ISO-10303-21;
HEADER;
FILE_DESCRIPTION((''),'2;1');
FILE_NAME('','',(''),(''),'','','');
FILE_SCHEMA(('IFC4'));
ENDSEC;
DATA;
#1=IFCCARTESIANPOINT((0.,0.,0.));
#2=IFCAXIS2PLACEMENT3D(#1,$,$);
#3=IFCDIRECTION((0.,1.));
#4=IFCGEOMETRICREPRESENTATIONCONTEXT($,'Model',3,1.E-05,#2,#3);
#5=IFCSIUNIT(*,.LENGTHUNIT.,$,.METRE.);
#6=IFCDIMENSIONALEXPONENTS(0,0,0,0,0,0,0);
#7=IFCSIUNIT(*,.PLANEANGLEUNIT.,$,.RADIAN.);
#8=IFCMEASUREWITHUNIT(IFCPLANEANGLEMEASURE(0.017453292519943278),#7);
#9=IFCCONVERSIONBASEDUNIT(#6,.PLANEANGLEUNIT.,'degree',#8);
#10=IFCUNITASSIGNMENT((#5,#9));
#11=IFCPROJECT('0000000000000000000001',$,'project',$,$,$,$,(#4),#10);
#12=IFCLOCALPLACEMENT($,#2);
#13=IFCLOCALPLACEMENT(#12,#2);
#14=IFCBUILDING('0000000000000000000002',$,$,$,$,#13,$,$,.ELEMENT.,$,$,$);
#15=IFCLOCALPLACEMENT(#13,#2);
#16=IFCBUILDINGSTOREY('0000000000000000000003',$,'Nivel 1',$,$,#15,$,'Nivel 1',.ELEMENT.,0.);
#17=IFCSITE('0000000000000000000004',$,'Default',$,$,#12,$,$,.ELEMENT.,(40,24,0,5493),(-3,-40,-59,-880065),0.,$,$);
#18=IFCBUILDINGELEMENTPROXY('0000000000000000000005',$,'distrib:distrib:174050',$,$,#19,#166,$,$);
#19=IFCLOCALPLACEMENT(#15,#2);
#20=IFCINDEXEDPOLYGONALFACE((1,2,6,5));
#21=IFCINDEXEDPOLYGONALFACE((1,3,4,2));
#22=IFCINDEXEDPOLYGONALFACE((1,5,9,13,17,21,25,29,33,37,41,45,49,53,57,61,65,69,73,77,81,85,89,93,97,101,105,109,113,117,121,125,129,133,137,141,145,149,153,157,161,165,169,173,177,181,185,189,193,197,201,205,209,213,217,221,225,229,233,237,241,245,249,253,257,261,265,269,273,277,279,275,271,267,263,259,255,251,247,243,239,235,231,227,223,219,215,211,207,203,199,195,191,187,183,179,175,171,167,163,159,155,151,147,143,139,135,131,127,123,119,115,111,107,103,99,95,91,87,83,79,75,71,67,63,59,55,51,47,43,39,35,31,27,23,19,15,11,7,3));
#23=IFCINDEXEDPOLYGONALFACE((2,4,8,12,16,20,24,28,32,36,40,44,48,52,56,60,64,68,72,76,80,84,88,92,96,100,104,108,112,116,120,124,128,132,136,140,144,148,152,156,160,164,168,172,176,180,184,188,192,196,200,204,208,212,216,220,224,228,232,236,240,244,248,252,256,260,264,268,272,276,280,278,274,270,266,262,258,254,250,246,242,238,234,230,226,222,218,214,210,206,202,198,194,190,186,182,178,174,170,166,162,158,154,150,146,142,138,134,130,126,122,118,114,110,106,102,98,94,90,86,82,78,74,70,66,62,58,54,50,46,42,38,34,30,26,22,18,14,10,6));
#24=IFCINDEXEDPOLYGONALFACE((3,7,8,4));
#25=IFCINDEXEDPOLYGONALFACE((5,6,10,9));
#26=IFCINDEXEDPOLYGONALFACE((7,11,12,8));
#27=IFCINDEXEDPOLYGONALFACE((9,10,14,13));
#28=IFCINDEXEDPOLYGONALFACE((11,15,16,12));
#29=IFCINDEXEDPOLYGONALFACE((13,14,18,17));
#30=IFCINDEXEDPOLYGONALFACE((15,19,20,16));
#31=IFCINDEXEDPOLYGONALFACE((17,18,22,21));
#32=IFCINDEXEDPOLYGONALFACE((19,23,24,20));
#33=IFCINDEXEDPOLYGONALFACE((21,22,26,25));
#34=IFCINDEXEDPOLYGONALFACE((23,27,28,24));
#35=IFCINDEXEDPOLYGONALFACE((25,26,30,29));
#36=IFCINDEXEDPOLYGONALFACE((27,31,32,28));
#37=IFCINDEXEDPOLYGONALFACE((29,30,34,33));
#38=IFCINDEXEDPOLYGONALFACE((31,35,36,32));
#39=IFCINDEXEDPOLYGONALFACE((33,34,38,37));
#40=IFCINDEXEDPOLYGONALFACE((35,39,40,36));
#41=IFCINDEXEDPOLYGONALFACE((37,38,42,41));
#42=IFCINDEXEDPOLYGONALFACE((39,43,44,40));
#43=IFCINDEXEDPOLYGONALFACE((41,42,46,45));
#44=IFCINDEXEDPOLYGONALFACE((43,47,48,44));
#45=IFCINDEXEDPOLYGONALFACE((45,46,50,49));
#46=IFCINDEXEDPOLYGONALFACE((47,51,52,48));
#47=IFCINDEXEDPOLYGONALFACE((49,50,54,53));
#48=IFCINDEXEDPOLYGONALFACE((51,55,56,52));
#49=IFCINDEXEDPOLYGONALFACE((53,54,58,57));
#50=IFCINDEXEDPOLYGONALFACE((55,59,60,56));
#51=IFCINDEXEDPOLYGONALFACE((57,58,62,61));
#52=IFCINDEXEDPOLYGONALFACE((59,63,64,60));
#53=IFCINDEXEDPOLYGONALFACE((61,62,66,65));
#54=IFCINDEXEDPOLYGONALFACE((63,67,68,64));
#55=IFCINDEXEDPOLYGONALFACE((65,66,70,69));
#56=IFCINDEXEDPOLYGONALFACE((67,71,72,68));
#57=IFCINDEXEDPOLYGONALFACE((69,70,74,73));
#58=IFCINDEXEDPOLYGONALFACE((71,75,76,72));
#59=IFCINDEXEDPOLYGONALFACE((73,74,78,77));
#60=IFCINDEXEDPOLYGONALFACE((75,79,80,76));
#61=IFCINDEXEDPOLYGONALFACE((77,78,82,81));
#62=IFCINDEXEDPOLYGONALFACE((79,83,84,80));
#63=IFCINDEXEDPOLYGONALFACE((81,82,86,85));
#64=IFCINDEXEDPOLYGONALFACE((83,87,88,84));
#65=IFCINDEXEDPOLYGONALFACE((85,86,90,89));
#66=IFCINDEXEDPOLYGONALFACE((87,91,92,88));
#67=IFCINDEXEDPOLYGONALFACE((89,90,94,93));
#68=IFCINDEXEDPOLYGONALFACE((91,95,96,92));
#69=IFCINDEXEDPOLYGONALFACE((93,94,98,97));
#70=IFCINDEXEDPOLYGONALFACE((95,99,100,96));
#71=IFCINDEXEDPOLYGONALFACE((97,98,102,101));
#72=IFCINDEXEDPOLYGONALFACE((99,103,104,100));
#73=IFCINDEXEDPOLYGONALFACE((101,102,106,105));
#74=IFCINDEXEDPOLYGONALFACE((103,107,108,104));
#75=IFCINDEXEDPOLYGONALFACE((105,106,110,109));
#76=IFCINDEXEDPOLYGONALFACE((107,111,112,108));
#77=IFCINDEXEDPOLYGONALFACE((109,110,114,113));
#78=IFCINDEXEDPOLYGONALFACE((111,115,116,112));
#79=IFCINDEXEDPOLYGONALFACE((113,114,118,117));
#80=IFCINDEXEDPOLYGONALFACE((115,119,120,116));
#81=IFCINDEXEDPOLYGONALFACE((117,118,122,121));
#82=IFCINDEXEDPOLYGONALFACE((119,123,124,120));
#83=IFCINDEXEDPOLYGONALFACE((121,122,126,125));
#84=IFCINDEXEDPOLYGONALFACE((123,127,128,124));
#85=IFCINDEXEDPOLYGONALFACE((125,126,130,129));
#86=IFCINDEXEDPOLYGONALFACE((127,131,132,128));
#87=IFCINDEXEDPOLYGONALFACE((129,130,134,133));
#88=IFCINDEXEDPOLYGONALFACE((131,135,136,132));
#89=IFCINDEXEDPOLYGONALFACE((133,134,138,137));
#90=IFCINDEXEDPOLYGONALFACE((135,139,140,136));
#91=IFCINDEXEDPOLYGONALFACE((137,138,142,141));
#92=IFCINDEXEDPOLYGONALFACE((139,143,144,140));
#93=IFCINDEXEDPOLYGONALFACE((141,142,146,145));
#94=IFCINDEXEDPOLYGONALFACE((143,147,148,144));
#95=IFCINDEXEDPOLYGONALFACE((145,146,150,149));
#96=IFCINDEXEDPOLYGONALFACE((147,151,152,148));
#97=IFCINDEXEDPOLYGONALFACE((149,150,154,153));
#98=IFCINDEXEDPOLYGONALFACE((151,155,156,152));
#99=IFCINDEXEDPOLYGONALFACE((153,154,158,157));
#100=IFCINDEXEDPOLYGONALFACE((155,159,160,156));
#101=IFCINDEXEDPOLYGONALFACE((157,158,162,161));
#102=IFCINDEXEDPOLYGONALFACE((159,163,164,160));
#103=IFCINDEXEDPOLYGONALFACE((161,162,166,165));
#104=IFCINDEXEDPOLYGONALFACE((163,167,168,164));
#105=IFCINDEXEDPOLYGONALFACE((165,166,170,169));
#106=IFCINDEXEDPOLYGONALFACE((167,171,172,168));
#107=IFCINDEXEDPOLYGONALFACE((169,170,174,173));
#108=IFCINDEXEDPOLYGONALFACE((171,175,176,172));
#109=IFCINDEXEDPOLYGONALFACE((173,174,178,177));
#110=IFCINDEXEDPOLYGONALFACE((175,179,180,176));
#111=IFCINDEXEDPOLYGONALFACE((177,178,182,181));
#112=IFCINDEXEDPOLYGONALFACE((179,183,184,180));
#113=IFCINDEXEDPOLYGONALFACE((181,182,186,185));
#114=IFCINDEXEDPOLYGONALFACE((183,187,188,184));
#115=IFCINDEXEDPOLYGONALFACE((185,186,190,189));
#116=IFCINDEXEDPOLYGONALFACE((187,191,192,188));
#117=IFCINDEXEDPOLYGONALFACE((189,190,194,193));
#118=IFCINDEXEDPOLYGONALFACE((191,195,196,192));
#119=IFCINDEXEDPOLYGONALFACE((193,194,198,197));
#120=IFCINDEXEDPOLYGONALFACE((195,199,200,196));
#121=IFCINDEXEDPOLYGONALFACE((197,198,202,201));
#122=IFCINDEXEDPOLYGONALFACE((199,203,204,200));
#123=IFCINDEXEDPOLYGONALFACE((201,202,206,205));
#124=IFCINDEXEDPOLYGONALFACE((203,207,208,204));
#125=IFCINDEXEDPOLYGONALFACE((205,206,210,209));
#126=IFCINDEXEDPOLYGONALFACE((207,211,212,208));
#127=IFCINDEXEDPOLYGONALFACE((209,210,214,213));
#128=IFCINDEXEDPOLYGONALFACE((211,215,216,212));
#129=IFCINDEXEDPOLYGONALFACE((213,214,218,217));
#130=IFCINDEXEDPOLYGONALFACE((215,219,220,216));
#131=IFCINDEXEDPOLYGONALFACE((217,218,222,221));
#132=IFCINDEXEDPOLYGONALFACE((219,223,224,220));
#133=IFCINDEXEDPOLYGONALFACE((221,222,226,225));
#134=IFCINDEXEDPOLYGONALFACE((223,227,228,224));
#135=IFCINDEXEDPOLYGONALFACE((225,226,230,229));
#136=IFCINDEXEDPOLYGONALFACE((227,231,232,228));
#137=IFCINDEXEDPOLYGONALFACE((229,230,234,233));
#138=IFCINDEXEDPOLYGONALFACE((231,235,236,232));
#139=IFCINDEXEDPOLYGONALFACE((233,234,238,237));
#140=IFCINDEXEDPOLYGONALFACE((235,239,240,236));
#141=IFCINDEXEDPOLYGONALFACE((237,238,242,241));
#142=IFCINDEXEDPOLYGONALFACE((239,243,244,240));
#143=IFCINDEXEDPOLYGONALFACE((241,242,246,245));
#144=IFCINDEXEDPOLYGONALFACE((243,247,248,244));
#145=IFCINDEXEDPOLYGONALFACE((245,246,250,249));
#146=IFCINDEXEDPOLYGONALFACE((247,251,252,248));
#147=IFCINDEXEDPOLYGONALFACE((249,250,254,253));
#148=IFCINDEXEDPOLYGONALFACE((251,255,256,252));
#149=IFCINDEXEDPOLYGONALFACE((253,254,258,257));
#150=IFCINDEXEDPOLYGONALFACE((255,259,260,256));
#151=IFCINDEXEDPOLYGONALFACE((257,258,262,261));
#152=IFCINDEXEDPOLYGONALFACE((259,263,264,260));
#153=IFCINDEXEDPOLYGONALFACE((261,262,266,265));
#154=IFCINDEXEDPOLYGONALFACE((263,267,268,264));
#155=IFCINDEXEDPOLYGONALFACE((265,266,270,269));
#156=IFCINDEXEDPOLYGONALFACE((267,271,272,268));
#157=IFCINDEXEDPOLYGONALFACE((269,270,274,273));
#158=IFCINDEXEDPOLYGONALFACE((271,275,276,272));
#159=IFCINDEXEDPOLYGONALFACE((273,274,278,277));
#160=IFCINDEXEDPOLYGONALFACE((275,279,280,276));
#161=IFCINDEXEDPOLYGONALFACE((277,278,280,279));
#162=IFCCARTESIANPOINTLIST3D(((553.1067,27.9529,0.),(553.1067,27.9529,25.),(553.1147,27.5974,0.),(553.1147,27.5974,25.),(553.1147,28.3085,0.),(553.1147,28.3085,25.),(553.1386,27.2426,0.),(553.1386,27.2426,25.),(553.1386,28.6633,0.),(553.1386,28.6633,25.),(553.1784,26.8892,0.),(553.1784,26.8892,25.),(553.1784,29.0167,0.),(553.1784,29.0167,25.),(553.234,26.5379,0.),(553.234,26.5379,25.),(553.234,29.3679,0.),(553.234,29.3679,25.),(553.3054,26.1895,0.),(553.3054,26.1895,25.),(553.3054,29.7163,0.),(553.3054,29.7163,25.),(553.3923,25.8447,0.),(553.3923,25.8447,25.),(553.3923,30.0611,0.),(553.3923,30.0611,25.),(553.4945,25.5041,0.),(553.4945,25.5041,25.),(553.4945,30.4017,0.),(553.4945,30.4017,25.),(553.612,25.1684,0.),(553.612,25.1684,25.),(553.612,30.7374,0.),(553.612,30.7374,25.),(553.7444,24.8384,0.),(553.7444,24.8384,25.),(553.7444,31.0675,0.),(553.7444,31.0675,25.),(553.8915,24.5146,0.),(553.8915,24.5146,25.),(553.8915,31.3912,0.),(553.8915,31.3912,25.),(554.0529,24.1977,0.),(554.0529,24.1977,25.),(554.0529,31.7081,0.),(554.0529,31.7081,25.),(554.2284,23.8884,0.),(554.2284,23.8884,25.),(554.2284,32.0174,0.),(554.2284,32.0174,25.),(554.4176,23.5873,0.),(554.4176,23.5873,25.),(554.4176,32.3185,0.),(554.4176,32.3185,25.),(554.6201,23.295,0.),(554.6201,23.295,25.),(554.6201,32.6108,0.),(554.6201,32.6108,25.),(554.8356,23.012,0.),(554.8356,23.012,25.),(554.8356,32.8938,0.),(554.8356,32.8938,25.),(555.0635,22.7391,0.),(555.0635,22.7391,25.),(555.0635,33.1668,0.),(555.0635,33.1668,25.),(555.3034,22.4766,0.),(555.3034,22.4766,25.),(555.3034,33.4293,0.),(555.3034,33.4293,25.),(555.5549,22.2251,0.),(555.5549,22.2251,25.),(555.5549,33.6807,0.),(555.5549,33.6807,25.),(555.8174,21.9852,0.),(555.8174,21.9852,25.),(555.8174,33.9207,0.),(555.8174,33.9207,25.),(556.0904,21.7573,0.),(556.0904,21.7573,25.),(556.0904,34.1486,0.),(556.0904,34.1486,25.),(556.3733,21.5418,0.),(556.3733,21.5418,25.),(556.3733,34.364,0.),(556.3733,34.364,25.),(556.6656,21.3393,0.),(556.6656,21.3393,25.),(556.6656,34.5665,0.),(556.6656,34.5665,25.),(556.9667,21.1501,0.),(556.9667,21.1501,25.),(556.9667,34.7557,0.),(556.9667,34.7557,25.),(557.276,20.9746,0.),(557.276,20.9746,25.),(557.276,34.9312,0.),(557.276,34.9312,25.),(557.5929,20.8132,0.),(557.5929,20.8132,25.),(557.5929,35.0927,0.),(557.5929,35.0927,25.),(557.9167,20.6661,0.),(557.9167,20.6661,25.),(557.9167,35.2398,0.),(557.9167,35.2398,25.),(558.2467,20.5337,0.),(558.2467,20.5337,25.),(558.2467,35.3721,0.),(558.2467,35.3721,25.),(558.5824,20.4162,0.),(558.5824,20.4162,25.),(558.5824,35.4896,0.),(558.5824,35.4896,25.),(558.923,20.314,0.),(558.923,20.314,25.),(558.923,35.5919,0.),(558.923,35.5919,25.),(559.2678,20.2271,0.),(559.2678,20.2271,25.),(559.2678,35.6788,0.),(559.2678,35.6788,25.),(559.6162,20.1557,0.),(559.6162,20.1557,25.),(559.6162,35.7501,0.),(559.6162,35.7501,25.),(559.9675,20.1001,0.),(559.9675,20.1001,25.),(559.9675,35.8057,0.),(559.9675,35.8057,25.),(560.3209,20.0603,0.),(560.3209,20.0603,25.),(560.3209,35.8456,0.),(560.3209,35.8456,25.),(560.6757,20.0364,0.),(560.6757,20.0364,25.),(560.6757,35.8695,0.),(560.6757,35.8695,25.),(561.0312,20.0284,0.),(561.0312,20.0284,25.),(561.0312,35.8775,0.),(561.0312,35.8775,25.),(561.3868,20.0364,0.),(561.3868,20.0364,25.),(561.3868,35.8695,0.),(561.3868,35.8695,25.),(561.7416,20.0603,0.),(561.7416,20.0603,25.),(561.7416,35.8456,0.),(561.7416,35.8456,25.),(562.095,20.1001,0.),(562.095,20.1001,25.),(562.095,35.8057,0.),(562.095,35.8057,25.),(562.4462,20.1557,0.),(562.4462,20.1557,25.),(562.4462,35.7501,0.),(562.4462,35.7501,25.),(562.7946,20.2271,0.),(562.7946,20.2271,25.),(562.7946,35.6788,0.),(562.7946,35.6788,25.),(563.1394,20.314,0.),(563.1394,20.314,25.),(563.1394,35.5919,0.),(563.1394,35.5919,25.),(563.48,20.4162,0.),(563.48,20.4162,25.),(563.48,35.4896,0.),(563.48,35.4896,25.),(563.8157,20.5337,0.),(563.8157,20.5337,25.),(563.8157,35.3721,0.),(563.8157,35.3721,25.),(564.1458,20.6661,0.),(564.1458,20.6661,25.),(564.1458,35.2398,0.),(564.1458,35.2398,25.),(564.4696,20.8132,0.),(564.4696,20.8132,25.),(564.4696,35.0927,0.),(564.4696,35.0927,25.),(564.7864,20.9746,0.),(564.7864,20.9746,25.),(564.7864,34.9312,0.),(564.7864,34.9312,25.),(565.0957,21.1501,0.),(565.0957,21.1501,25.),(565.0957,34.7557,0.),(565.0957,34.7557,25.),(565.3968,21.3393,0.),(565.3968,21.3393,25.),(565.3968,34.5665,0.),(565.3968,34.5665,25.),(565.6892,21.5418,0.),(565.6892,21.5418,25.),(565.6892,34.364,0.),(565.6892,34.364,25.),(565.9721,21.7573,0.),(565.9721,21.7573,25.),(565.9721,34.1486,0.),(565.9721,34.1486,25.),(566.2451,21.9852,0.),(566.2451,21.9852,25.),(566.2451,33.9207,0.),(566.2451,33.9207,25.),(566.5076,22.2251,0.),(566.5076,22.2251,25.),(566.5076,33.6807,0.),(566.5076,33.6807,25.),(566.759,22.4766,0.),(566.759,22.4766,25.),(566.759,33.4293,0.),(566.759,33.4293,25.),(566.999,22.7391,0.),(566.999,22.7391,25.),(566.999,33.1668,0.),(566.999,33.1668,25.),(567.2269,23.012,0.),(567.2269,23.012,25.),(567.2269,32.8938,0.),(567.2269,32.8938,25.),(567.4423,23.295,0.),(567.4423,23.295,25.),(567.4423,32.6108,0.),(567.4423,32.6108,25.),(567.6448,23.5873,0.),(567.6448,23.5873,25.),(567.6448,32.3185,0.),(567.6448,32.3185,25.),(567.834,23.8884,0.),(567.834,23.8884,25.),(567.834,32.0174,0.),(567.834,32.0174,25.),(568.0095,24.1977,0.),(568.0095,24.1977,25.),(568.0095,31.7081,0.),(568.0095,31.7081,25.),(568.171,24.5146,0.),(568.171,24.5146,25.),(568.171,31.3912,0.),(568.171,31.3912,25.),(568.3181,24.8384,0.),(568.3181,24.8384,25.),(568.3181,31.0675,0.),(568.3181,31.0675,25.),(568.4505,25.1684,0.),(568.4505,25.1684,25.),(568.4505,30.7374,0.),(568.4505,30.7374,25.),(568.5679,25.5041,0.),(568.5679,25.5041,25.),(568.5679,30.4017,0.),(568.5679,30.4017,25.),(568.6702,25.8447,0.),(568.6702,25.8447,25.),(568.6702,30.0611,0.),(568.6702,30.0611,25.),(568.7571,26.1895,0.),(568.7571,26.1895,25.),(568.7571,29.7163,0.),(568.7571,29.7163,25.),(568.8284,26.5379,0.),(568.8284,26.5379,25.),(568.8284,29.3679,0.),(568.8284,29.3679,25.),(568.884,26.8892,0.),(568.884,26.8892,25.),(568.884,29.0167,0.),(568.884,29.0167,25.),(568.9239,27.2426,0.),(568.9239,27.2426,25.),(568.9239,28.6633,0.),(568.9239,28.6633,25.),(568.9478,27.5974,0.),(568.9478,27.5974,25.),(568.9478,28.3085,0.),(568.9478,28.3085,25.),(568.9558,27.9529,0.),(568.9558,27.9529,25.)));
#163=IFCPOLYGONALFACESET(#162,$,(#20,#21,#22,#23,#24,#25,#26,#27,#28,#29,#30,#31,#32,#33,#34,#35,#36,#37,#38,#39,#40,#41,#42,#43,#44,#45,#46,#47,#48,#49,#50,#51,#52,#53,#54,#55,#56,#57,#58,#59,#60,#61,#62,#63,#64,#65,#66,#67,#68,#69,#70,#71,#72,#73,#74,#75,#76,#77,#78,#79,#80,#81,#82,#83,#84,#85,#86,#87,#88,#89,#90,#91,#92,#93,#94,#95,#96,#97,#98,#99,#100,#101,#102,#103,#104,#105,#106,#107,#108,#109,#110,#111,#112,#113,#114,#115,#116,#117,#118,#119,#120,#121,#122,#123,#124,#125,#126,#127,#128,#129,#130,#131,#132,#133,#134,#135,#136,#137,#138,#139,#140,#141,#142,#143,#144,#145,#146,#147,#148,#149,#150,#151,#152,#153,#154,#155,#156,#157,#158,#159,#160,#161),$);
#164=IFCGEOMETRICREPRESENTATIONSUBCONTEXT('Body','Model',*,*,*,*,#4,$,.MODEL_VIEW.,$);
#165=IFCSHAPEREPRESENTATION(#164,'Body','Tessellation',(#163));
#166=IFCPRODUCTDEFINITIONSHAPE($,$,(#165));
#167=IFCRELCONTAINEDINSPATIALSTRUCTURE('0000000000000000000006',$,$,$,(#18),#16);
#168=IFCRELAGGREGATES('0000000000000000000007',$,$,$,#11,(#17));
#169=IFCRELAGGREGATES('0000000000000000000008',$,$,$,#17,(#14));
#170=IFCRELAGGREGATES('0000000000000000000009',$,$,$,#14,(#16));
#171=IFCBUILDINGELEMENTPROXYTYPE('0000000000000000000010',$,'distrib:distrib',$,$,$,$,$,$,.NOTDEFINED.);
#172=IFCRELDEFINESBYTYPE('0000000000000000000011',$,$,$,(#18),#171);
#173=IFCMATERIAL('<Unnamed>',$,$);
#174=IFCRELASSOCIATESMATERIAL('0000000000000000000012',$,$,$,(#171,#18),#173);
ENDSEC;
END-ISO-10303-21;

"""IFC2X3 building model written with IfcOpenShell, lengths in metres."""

from ifc_helpers import new_model, entity, si_unit, converted_unit, direction, frame, frame_2d, origin, place, context, subcontext, project, spatial, circle, extrude, source, transform, mapped, material, type_object, type_shapes, element, save


model = new_model("IFC2X3")

# Units and contexts
model_context = context("Model", 3, precision=1e-05, world=origin(), true_north=direction((0.0, 1.0)))
body_context = subcontext(model_context, "Body", "Model", "MODEL_VIEW")
ifc_project = project(units=[si_unit("LENGTHUNIT", "METRE"), converted_unit("PLANEANGLEUNIT", "degree", entity("IfcPlaneAngleMeasure", 0.017453292519943278), si_unit("PLANEANGLEUNIT", "RADIAN"), dimensions=[0, 0, 0, 0, 0, 0, 0])], contexts=[model_context])

# Site, building, storey
site_placement = place(None, origin())
site = spatial("IfcSite", under=ifc_project, at=site_placement, Name="Default", CompositionType="ELEMENT", RefLatitude=(40, 24, 0, 5493), RefLongitude=(-3, -40, -59, -880065), RefElevation=0.0)
building_placement = place(site_placement, origin())
building = spatial("IfcBuilding", under=site, at=building_placement, CompositionType="ELEMENT")
storey_placement = place(building_placement, origin())
storey = spatial("IfcBuildingStorey", under=building, at=storey_placement, Name="Nivel 1", LongName="Nivel 1", CompositionType="ELEMENT", Elevation=0.0)

# Building element proxy
ifc_material_1 = material(Name="<Unnamed>")
building_element_proxy_type_1 = type_object("IfcBuildingElementProxyType", Name="distrib:distrib", PredefinedType="NOTDEFINED", material=ifc_material_1)
shared_shape_1 = source(origin(), body_context, "Body", "SweptSolid", [
    extrude(circle(Radius=7.9245, at=frame_2d((0.0, 0.0), x_axis=(1.0, 0.0))), frame((561.0312, 27.9529, 0.0)), (0.0, 0.0, 1.0), 25.0),
])
type_shapes(building_element_proxy_type_1, [shared_shape_1])
proxy_1_placement = place(storey_placement, origin())
element("IfcBuildingElementProxy", 1, at=proxy_1_placement, inside=storey, type_object=building_element_proxy_type_1, material=ifc_material_1, Name="distrib:distrib:174050", context=body_context, shape_type="MappedRepresentation", body=[
    mapped(shared_shape_1, transform((0.0, 0.0, 0.0), scale=1.0)),
])

save(model, "model.ifc")
